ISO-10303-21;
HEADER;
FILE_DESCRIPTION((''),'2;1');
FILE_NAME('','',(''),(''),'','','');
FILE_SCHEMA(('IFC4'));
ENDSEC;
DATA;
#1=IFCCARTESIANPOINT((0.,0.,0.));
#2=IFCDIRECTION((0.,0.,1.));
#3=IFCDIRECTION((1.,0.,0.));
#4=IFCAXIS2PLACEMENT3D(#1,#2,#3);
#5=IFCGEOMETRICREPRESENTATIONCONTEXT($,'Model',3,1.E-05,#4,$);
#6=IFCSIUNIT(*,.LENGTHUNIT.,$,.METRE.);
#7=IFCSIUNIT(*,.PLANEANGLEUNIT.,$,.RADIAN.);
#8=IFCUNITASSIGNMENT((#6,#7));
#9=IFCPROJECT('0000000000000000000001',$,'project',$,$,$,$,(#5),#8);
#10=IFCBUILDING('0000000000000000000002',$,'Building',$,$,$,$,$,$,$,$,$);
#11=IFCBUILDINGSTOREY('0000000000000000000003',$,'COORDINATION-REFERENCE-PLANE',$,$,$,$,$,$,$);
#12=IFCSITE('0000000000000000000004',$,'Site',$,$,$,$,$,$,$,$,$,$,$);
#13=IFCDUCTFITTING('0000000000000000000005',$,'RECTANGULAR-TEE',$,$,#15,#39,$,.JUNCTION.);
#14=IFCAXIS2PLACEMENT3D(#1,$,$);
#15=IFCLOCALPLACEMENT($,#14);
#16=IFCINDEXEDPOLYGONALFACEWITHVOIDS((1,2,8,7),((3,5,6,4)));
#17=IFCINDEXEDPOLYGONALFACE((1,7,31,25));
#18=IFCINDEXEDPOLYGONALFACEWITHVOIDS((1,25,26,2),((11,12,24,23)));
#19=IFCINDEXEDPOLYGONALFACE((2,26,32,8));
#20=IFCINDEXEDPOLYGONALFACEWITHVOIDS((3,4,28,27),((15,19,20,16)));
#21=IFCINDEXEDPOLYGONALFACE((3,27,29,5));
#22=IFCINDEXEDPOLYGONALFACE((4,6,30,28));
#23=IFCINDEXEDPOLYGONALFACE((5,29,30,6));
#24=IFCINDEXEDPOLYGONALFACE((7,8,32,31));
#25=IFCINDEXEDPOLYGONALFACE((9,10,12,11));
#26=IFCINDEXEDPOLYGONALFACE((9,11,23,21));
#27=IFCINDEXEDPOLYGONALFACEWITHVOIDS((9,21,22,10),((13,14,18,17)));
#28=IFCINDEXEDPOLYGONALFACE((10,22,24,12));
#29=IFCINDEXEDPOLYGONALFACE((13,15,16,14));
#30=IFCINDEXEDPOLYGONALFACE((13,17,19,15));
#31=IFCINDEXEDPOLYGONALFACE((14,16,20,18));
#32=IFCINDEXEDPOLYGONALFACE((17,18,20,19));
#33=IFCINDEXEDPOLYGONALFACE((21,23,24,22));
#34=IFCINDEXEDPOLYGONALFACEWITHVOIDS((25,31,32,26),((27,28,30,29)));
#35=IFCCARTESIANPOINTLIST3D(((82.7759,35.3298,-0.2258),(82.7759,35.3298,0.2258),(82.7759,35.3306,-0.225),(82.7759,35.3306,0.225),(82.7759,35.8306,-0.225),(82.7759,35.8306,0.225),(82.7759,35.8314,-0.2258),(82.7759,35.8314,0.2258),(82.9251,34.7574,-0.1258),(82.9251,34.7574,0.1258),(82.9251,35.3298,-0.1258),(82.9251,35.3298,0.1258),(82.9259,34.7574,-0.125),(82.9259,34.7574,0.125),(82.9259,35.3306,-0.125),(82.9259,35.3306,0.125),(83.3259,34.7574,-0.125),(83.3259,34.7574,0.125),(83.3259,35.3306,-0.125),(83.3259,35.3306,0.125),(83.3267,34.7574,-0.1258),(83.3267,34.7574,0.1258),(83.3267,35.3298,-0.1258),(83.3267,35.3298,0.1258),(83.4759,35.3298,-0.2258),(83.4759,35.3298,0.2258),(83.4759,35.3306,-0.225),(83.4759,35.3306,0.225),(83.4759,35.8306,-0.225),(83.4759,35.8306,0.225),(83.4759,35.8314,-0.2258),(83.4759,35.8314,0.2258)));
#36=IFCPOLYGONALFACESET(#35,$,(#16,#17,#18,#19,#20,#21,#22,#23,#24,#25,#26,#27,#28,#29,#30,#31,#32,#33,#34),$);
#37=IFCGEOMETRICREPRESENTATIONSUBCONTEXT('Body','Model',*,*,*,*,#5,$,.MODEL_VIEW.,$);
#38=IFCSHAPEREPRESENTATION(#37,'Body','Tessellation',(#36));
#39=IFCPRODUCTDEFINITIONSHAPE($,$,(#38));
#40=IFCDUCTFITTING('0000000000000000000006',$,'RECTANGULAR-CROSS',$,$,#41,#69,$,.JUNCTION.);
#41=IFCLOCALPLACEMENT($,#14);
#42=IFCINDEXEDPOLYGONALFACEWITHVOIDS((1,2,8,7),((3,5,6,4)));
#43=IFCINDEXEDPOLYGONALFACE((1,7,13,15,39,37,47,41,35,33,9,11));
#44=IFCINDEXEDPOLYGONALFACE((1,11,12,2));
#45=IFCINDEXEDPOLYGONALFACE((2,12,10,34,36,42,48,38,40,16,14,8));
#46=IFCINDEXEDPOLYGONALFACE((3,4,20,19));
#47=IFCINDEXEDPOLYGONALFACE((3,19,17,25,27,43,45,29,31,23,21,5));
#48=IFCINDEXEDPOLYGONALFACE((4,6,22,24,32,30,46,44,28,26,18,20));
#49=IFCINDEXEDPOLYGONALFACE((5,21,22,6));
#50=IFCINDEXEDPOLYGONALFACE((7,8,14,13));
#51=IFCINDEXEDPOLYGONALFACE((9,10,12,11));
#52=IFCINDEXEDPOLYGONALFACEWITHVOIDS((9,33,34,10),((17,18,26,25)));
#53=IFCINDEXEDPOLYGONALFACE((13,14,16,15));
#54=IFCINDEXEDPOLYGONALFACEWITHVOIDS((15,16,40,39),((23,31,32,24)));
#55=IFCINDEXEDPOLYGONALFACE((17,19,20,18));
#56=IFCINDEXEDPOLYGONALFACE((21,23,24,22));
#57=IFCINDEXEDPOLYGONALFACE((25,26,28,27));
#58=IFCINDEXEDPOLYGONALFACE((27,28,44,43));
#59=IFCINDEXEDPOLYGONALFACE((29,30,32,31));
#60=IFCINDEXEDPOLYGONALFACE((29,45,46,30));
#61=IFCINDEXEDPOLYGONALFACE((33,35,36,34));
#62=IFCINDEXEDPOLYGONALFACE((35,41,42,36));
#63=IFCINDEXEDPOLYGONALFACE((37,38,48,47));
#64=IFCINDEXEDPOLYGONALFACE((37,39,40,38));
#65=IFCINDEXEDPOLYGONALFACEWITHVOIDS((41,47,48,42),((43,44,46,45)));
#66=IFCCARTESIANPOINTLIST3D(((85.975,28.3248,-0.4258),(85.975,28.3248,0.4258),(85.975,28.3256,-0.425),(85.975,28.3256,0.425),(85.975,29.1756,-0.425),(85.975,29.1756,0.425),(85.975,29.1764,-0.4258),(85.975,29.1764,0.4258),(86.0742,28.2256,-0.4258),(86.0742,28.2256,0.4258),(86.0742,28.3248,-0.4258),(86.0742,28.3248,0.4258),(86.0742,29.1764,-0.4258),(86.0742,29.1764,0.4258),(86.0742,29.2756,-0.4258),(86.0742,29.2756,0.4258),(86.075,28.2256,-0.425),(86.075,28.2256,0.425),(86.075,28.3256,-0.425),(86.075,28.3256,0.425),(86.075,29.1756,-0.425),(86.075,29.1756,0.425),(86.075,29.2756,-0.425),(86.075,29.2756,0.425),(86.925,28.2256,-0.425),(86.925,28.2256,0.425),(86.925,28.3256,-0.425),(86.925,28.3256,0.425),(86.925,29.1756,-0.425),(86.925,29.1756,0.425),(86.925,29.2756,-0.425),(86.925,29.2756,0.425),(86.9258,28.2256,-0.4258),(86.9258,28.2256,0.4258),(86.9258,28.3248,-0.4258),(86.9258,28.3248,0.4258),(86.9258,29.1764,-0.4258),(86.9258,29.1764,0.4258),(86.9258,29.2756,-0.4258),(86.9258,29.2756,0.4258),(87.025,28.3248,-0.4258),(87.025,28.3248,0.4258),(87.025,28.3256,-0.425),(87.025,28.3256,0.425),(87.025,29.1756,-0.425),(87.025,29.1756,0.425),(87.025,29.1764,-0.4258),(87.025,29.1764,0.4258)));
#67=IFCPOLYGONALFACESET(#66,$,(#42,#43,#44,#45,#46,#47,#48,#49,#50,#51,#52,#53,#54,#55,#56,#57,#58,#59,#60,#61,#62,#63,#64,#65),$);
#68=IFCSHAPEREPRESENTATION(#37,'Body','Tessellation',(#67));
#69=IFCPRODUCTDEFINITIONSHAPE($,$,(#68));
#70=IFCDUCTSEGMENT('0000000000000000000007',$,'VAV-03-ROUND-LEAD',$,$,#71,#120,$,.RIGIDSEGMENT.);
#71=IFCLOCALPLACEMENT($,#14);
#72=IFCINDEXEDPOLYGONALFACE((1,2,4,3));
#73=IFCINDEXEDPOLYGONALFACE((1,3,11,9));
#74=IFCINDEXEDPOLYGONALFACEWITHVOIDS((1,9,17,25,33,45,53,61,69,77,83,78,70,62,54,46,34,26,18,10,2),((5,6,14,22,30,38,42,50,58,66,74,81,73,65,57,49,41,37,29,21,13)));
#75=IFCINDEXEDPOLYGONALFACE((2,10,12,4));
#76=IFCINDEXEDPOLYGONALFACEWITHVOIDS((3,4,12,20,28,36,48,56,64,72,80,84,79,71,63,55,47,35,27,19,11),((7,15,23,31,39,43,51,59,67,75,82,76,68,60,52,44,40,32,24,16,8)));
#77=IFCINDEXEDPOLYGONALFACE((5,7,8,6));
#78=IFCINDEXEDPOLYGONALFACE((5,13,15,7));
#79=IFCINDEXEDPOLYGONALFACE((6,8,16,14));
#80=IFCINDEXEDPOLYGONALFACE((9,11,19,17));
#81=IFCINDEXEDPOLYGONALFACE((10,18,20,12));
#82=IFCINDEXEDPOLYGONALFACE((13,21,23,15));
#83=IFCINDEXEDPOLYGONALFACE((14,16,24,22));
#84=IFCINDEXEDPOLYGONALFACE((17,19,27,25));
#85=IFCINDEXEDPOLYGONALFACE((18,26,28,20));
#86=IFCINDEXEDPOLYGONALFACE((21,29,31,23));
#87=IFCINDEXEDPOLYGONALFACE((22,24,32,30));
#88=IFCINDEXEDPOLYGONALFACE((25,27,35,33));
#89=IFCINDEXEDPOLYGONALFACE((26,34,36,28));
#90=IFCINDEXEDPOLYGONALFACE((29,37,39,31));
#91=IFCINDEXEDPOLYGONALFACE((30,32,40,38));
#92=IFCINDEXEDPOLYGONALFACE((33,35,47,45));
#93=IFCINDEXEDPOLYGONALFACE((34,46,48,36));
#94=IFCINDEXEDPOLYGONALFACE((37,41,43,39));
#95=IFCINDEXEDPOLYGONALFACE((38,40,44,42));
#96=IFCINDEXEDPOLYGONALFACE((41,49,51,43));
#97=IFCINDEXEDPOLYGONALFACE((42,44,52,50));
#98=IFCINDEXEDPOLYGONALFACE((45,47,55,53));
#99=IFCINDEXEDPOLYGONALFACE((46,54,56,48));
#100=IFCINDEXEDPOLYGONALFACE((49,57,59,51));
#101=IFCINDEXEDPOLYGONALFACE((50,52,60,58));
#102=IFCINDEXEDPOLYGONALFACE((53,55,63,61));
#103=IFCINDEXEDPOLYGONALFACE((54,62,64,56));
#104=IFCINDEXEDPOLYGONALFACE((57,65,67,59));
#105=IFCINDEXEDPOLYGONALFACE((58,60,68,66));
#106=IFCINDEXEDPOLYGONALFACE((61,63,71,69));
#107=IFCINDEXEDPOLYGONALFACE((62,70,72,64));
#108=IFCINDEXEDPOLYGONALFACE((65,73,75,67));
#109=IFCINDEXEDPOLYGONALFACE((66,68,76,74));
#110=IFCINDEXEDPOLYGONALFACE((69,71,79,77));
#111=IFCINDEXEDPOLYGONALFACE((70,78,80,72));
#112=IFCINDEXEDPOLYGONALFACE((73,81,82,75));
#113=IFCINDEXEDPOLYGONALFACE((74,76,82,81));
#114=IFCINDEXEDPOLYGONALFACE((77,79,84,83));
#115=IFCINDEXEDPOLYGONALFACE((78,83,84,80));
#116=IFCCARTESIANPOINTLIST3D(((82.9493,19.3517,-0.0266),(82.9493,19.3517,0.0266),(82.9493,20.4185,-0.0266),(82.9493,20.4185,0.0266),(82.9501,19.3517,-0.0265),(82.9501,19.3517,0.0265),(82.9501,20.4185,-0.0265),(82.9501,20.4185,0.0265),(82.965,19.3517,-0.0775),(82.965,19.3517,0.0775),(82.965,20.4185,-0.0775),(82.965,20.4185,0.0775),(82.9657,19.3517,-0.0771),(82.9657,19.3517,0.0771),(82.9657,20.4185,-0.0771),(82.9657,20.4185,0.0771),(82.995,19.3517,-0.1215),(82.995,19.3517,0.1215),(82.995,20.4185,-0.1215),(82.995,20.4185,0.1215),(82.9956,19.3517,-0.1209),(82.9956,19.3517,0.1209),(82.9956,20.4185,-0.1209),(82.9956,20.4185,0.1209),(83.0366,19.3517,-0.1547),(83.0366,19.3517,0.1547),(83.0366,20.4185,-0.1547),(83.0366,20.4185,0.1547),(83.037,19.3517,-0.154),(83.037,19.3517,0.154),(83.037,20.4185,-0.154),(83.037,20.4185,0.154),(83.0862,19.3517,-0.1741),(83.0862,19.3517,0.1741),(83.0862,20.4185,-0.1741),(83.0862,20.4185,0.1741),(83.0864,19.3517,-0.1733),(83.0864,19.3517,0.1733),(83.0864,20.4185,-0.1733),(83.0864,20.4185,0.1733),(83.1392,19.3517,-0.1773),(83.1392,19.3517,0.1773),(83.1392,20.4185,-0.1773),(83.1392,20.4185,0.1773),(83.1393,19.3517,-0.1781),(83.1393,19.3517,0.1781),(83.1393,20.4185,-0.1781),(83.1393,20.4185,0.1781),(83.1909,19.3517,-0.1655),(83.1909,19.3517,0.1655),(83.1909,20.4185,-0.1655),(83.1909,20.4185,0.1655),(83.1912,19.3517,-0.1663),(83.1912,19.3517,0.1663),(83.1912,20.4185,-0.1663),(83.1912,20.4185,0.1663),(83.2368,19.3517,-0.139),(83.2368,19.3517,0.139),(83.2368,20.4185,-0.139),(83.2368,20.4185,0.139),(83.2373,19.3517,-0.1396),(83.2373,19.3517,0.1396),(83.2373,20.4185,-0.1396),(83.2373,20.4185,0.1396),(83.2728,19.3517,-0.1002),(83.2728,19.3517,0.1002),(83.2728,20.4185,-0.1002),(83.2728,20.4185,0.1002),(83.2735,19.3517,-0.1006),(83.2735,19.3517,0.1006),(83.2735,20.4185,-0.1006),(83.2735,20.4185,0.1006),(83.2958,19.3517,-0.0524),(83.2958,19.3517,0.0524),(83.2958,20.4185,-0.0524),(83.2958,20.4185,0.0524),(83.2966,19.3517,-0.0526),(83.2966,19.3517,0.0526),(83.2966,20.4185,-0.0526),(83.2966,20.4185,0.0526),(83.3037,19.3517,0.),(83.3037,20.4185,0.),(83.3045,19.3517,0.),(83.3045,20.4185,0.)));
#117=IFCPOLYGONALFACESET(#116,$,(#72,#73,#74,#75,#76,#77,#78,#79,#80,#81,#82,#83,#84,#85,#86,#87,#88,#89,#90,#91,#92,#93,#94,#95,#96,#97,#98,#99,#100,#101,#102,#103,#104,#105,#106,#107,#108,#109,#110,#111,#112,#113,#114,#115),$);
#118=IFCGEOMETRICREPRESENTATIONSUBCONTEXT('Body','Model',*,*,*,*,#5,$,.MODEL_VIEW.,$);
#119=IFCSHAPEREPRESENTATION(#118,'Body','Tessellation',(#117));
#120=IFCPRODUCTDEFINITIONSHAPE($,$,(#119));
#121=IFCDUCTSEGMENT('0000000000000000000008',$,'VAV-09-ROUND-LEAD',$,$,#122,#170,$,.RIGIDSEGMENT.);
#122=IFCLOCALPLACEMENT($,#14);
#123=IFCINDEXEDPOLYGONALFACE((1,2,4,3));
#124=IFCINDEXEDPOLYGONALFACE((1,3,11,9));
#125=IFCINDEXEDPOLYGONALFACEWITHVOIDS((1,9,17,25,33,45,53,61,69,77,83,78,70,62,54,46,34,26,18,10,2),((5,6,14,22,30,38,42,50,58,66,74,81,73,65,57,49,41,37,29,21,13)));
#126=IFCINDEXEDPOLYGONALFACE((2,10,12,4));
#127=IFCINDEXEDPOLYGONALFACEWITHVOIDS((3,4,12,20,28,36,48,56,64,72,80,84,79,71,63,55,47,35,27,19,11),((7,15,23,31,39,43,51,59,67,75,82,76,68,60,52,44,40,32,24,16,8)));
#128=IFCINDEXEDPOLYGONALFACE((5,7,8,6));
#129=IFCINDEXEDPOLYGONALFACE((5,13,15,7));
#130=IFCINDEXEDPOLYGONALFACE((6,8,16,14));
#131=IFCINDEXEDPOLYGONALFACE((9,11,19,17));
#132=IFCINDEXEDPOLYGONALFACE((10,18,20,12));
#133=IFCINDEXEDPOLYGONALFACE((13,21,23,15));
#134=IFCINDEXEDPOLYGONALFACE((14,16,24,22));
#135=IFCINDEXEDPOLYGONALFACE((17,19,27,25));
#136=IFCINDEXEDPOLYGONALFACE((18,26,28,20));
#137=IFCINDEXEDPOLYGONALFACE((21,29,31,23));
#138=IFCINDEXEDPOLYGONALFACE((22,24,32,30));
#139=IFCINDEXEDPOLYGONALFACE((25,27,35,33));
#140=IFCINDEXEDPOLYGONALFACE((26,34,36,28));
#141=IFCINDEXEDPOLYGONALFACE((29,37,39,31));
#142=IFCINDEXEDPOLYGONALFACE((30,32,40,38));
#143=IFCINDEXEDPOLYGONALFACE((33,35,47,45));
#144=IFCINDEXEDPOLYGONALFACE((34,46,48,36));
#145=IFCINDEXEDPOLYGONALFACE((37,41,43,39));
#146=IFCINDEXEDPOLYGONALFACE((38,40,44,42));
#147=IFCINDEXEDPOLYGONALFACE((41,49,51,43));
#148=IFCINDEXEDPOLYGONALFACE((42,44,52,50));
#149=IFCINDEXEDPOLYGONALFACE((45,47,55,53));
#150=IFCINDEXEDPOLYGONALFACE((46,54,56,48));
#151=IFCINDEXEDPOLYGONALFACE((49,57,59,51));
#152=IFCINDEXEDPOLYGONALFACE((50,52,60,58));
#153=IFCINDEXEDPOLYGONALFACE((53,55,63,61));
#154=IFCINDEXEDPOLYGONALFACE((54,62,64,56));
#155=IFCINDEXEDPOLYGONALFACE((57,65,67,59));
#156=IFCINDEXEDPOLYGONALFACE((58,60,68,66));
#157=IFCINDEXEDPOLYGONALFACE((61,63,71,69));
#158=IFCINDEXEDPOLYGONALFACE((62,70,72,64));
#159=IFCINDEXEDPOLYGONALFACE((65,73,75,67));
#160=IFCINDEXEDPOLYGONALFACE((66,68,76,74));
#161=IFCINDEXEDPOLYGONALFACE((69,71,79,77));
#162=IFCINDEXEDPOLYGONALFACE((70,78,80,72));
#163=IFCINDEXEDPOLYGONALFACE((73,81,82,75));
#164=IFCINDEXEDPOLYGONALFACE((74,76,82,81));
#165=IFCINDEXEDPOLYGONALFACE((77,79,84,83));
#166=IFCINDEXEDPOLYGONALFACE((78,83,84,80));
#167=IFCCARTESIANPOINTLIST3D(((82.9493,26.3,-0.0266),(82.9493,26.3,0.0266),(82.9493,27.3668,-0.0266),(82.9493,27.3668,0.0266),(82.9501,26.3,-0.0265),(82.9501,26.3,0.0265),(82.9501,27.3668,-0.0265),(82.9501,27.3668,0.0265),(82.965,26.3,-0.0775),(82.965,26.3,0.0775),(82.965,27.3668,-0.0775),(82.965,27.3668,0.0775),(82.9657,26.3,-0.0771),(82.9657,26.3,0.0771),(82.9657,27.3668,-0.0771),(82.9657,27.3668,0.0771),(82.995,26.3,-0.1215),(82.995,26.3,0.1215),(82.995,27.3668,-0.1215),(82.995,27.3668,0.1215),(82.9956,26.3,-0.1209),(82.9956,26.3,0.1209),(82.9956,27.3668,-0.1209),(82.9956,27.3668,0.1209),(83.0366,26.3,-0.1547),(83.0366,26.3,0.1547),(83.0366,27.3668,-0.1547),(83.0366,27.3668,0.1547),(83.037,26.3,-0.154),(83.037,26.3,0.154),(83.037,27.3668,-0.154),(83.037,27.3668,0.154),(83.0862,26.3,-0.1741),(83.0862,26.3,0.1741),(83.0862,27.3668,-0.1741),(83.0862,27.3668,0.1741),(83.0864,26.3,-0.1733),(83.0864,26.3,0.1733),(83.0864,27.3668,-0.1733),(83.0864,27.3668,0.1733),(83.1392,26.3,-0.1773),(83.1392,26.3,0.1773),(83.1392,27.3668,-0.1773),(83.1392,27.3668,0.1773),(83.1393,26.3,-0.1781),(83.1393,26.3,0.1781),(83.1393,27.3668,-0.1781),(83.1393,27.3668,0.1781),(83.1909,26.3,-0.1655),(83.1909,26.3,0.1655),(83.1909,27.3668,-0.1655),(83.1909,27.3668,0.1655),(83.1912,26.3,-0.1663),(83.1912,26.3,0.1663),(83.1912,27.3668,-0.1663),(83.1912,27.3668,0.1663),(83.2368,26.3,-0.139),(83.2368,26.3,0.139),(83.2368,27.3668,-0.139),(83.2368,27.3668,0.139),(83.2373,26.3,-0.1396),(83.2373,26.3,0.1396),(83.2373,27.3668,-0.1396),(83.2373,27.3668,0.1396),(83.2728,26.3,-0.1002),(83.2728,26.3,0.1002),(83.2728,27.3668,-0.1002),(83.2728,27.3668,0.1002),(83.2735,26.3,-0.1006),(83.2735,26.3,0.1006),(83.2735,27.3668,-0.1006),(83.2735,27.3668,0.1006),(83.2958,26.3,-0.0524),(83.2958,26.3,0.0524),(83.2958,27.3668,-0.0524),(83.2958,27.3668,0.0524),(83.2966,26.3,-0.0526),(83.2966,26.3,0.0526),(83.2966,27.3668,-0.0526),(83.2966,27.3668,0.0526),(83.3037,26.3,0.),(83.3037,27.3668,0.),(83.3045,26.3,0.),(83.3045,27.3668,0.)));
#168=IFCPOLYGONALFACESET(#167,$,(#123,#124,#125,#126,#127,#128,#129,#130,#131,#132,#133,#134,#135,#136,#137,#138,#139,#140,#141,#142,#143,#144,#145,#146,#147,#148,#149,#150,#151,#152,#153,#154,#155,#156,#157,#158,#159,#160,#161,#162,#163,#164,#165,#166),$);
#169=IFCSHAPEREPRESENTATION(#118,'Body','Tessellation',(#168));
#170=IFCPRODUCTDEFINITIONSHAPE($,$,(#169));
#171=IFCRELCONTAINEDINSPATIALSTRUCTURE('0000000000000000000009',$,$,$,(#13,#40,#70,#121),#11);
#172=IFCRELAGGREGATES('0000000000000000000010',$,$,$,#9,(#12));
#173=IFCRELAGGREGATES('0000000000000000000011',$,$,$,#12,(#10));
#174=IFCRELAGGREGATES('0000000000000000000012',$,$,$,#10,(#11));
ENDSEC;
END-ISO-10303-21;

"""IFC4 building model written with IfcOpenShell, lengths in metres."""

from ifc_helpers import new_model, si_unit, frame, origin, origin_with_axes, place, context, subcontext, project, spatial, rectangle, hollow_circle, extrude, boolean, element, save


model = new_model("IFC4")

# Units and contexts
model_context = context("Model", 3, precision=1e-05, world=origin_with_axes())
body_context_1 = subcontext(model_context, "Body", "Model", "MODEL_VIEW")
body_context_2 = subcontext(model_context, "Body", "Model", "MODEL_VIEW")
ifc_project = project(units=[si_unit("LENGTHUNIT", "METRE"), si_unit("PLANEANGLEUNIT", "RADIAN")], contexts=[model_context])

# Site, building, storey
site = spatial("IfcSite", under=ifc_project, Name="Site")
building = spatial("IfcBuilding", under=site, Name="Building")
storey = spatial("IfcBuildingStorey", under=building, Name="COORDINATION-REFERENCE-PLANE")

# Duct fittings
duct_fitting_1_placement = place(None, frame((83.1259, 35.5806, 0.0), z_axis=(-1.0, 0.0, 0.0), x_axis=(0.0, -1.0, 0.0)))
solid_1 = boolean("UNION", extrude(rectangle(XDim=0.5, YDim=0.45), frame((0.0, 0.0, -0.35), z_axis=(0.0, 0.0, 1.0), x_axis=(1.0, 0.0, 0.0)), (0.0, 0.0, 1.0), 0.7), extrude(rectangle(XDim=0.4, YDim=0.25), frame((0.0, 0.0, 0.0), z_axis=(1.0, 0.0, 0.0), x_axis=(0.0, 0.0, -1.0)), (0.0, 0.0, 1.0), 0.8232))
element("IfcDuctFitting", 1, at=duct_fitting_1_placement, inside=storey, Name="RECTANGULAR-TEE", PredefinedType="JUNCTION", context=body_context_1, shape_type="CSG", body=[
    boolean("DIFFERENCE", boolean("UNION", extrude(rectangle(XDim=0.5016, YDim=0.4516), frame((0.0, 0.0, -0.35), z_axis=(0.0, 0.0, 1.0), x_axis=(1.0, 0.0, 0.0)), (0.0, 0.0, 1.0), 0.7), extrude(rectangle(XDim=0.4016, YDim=0.2516), frame((0.0, 0.0, 0.0), z_axis=(1.0, 0.0, 0.0), x_axis=(0.0, 0.0, -1.0)), (0.0, 0.0, 1.0), 0.8232)), solid_1),
])
duct_fitting_2_placement = place(None, frame((86.5, 28.7506, 0.0), z_axis=(0.0, -1.0, 0.0), x_axis=(1.0, 0.0, 0.0)))
solid_2 = boolean("UNION", extrude(rectangle(XDim=0.85, YDim=0.85), frame((0.0, 0.0, -0.525), z_axis=(0.0, 0.0, 1.0), x_axis=(1.0, 0.0, 0.0)), (0.0, 0.0, 1.0), 1.05), extrude(rectangle(XDim=0.85, YDim=0.85), frame((-0.525, 0.0, 0.0), z_axis=(1.0, 0.0, 0.0), x_axis=(0.0, 0.0, -1.0)), (0.0, 0.0, 1.0), 1.05))
element("IfcDuctFitting", 2, at=duct_fitting_2_placement, inside=storey, Name="RECTANGULAR-CROSS", PredefinedType="JUNCTION", context=body_context_1, shape_type="CSG", body=[
    boolean("DIFFERENCE", boolean("UNION", extrude(rectangle(XDim=0.8516, YDim=0.8516), frame((0.0, 0.0, -0.525), z_axis=(0.0, 0.0, 1.0), x_axis=(1.0, 0.0, 0.0)), (0.0, 0.0, 1.0), 1.05), extrude(rectangle(XDim=0.8516, YDim=0.8516), frame((-0.525, 0.0, 0.0), z_axis=(1.0, 0.0, 0.0), x_axis=(0.0, 0.0, -1.0)), (0.0, 0.0, 1.0), 1.05)), solid_2),
])

# Duct segments
for number, where, z_axis, x_axis, name in (
    (3, (83.1259, 20.4185, 0.0), (0.0, -1.0, 0.0), (1.0, 0.0, 0.0), "VAV-03-ROUND-LEAD"),
    (4, (83.1259, 27.3668, 0.0), (0.0, -1.0, 0.0), (1.0, 0.0, 0.0), "VAV-09-ROUND-LEAD"),
):
    element("IfcDuctSegment", number, at=place(None, frame(where, z_axis=z_axis, x_axis=x_axis)), inside=storey, Name=name, PredefinedType="RIGIDSEGMENT", context=body_context_2, shape_type="SweptSolid", body=[
        extrude(hollow_circle(Radius=0.1786, WallThickness=0.0008), origin(), (0.0, 0.0, 1.0), 1.0668),
    ])

save(model, "model.ifc")
